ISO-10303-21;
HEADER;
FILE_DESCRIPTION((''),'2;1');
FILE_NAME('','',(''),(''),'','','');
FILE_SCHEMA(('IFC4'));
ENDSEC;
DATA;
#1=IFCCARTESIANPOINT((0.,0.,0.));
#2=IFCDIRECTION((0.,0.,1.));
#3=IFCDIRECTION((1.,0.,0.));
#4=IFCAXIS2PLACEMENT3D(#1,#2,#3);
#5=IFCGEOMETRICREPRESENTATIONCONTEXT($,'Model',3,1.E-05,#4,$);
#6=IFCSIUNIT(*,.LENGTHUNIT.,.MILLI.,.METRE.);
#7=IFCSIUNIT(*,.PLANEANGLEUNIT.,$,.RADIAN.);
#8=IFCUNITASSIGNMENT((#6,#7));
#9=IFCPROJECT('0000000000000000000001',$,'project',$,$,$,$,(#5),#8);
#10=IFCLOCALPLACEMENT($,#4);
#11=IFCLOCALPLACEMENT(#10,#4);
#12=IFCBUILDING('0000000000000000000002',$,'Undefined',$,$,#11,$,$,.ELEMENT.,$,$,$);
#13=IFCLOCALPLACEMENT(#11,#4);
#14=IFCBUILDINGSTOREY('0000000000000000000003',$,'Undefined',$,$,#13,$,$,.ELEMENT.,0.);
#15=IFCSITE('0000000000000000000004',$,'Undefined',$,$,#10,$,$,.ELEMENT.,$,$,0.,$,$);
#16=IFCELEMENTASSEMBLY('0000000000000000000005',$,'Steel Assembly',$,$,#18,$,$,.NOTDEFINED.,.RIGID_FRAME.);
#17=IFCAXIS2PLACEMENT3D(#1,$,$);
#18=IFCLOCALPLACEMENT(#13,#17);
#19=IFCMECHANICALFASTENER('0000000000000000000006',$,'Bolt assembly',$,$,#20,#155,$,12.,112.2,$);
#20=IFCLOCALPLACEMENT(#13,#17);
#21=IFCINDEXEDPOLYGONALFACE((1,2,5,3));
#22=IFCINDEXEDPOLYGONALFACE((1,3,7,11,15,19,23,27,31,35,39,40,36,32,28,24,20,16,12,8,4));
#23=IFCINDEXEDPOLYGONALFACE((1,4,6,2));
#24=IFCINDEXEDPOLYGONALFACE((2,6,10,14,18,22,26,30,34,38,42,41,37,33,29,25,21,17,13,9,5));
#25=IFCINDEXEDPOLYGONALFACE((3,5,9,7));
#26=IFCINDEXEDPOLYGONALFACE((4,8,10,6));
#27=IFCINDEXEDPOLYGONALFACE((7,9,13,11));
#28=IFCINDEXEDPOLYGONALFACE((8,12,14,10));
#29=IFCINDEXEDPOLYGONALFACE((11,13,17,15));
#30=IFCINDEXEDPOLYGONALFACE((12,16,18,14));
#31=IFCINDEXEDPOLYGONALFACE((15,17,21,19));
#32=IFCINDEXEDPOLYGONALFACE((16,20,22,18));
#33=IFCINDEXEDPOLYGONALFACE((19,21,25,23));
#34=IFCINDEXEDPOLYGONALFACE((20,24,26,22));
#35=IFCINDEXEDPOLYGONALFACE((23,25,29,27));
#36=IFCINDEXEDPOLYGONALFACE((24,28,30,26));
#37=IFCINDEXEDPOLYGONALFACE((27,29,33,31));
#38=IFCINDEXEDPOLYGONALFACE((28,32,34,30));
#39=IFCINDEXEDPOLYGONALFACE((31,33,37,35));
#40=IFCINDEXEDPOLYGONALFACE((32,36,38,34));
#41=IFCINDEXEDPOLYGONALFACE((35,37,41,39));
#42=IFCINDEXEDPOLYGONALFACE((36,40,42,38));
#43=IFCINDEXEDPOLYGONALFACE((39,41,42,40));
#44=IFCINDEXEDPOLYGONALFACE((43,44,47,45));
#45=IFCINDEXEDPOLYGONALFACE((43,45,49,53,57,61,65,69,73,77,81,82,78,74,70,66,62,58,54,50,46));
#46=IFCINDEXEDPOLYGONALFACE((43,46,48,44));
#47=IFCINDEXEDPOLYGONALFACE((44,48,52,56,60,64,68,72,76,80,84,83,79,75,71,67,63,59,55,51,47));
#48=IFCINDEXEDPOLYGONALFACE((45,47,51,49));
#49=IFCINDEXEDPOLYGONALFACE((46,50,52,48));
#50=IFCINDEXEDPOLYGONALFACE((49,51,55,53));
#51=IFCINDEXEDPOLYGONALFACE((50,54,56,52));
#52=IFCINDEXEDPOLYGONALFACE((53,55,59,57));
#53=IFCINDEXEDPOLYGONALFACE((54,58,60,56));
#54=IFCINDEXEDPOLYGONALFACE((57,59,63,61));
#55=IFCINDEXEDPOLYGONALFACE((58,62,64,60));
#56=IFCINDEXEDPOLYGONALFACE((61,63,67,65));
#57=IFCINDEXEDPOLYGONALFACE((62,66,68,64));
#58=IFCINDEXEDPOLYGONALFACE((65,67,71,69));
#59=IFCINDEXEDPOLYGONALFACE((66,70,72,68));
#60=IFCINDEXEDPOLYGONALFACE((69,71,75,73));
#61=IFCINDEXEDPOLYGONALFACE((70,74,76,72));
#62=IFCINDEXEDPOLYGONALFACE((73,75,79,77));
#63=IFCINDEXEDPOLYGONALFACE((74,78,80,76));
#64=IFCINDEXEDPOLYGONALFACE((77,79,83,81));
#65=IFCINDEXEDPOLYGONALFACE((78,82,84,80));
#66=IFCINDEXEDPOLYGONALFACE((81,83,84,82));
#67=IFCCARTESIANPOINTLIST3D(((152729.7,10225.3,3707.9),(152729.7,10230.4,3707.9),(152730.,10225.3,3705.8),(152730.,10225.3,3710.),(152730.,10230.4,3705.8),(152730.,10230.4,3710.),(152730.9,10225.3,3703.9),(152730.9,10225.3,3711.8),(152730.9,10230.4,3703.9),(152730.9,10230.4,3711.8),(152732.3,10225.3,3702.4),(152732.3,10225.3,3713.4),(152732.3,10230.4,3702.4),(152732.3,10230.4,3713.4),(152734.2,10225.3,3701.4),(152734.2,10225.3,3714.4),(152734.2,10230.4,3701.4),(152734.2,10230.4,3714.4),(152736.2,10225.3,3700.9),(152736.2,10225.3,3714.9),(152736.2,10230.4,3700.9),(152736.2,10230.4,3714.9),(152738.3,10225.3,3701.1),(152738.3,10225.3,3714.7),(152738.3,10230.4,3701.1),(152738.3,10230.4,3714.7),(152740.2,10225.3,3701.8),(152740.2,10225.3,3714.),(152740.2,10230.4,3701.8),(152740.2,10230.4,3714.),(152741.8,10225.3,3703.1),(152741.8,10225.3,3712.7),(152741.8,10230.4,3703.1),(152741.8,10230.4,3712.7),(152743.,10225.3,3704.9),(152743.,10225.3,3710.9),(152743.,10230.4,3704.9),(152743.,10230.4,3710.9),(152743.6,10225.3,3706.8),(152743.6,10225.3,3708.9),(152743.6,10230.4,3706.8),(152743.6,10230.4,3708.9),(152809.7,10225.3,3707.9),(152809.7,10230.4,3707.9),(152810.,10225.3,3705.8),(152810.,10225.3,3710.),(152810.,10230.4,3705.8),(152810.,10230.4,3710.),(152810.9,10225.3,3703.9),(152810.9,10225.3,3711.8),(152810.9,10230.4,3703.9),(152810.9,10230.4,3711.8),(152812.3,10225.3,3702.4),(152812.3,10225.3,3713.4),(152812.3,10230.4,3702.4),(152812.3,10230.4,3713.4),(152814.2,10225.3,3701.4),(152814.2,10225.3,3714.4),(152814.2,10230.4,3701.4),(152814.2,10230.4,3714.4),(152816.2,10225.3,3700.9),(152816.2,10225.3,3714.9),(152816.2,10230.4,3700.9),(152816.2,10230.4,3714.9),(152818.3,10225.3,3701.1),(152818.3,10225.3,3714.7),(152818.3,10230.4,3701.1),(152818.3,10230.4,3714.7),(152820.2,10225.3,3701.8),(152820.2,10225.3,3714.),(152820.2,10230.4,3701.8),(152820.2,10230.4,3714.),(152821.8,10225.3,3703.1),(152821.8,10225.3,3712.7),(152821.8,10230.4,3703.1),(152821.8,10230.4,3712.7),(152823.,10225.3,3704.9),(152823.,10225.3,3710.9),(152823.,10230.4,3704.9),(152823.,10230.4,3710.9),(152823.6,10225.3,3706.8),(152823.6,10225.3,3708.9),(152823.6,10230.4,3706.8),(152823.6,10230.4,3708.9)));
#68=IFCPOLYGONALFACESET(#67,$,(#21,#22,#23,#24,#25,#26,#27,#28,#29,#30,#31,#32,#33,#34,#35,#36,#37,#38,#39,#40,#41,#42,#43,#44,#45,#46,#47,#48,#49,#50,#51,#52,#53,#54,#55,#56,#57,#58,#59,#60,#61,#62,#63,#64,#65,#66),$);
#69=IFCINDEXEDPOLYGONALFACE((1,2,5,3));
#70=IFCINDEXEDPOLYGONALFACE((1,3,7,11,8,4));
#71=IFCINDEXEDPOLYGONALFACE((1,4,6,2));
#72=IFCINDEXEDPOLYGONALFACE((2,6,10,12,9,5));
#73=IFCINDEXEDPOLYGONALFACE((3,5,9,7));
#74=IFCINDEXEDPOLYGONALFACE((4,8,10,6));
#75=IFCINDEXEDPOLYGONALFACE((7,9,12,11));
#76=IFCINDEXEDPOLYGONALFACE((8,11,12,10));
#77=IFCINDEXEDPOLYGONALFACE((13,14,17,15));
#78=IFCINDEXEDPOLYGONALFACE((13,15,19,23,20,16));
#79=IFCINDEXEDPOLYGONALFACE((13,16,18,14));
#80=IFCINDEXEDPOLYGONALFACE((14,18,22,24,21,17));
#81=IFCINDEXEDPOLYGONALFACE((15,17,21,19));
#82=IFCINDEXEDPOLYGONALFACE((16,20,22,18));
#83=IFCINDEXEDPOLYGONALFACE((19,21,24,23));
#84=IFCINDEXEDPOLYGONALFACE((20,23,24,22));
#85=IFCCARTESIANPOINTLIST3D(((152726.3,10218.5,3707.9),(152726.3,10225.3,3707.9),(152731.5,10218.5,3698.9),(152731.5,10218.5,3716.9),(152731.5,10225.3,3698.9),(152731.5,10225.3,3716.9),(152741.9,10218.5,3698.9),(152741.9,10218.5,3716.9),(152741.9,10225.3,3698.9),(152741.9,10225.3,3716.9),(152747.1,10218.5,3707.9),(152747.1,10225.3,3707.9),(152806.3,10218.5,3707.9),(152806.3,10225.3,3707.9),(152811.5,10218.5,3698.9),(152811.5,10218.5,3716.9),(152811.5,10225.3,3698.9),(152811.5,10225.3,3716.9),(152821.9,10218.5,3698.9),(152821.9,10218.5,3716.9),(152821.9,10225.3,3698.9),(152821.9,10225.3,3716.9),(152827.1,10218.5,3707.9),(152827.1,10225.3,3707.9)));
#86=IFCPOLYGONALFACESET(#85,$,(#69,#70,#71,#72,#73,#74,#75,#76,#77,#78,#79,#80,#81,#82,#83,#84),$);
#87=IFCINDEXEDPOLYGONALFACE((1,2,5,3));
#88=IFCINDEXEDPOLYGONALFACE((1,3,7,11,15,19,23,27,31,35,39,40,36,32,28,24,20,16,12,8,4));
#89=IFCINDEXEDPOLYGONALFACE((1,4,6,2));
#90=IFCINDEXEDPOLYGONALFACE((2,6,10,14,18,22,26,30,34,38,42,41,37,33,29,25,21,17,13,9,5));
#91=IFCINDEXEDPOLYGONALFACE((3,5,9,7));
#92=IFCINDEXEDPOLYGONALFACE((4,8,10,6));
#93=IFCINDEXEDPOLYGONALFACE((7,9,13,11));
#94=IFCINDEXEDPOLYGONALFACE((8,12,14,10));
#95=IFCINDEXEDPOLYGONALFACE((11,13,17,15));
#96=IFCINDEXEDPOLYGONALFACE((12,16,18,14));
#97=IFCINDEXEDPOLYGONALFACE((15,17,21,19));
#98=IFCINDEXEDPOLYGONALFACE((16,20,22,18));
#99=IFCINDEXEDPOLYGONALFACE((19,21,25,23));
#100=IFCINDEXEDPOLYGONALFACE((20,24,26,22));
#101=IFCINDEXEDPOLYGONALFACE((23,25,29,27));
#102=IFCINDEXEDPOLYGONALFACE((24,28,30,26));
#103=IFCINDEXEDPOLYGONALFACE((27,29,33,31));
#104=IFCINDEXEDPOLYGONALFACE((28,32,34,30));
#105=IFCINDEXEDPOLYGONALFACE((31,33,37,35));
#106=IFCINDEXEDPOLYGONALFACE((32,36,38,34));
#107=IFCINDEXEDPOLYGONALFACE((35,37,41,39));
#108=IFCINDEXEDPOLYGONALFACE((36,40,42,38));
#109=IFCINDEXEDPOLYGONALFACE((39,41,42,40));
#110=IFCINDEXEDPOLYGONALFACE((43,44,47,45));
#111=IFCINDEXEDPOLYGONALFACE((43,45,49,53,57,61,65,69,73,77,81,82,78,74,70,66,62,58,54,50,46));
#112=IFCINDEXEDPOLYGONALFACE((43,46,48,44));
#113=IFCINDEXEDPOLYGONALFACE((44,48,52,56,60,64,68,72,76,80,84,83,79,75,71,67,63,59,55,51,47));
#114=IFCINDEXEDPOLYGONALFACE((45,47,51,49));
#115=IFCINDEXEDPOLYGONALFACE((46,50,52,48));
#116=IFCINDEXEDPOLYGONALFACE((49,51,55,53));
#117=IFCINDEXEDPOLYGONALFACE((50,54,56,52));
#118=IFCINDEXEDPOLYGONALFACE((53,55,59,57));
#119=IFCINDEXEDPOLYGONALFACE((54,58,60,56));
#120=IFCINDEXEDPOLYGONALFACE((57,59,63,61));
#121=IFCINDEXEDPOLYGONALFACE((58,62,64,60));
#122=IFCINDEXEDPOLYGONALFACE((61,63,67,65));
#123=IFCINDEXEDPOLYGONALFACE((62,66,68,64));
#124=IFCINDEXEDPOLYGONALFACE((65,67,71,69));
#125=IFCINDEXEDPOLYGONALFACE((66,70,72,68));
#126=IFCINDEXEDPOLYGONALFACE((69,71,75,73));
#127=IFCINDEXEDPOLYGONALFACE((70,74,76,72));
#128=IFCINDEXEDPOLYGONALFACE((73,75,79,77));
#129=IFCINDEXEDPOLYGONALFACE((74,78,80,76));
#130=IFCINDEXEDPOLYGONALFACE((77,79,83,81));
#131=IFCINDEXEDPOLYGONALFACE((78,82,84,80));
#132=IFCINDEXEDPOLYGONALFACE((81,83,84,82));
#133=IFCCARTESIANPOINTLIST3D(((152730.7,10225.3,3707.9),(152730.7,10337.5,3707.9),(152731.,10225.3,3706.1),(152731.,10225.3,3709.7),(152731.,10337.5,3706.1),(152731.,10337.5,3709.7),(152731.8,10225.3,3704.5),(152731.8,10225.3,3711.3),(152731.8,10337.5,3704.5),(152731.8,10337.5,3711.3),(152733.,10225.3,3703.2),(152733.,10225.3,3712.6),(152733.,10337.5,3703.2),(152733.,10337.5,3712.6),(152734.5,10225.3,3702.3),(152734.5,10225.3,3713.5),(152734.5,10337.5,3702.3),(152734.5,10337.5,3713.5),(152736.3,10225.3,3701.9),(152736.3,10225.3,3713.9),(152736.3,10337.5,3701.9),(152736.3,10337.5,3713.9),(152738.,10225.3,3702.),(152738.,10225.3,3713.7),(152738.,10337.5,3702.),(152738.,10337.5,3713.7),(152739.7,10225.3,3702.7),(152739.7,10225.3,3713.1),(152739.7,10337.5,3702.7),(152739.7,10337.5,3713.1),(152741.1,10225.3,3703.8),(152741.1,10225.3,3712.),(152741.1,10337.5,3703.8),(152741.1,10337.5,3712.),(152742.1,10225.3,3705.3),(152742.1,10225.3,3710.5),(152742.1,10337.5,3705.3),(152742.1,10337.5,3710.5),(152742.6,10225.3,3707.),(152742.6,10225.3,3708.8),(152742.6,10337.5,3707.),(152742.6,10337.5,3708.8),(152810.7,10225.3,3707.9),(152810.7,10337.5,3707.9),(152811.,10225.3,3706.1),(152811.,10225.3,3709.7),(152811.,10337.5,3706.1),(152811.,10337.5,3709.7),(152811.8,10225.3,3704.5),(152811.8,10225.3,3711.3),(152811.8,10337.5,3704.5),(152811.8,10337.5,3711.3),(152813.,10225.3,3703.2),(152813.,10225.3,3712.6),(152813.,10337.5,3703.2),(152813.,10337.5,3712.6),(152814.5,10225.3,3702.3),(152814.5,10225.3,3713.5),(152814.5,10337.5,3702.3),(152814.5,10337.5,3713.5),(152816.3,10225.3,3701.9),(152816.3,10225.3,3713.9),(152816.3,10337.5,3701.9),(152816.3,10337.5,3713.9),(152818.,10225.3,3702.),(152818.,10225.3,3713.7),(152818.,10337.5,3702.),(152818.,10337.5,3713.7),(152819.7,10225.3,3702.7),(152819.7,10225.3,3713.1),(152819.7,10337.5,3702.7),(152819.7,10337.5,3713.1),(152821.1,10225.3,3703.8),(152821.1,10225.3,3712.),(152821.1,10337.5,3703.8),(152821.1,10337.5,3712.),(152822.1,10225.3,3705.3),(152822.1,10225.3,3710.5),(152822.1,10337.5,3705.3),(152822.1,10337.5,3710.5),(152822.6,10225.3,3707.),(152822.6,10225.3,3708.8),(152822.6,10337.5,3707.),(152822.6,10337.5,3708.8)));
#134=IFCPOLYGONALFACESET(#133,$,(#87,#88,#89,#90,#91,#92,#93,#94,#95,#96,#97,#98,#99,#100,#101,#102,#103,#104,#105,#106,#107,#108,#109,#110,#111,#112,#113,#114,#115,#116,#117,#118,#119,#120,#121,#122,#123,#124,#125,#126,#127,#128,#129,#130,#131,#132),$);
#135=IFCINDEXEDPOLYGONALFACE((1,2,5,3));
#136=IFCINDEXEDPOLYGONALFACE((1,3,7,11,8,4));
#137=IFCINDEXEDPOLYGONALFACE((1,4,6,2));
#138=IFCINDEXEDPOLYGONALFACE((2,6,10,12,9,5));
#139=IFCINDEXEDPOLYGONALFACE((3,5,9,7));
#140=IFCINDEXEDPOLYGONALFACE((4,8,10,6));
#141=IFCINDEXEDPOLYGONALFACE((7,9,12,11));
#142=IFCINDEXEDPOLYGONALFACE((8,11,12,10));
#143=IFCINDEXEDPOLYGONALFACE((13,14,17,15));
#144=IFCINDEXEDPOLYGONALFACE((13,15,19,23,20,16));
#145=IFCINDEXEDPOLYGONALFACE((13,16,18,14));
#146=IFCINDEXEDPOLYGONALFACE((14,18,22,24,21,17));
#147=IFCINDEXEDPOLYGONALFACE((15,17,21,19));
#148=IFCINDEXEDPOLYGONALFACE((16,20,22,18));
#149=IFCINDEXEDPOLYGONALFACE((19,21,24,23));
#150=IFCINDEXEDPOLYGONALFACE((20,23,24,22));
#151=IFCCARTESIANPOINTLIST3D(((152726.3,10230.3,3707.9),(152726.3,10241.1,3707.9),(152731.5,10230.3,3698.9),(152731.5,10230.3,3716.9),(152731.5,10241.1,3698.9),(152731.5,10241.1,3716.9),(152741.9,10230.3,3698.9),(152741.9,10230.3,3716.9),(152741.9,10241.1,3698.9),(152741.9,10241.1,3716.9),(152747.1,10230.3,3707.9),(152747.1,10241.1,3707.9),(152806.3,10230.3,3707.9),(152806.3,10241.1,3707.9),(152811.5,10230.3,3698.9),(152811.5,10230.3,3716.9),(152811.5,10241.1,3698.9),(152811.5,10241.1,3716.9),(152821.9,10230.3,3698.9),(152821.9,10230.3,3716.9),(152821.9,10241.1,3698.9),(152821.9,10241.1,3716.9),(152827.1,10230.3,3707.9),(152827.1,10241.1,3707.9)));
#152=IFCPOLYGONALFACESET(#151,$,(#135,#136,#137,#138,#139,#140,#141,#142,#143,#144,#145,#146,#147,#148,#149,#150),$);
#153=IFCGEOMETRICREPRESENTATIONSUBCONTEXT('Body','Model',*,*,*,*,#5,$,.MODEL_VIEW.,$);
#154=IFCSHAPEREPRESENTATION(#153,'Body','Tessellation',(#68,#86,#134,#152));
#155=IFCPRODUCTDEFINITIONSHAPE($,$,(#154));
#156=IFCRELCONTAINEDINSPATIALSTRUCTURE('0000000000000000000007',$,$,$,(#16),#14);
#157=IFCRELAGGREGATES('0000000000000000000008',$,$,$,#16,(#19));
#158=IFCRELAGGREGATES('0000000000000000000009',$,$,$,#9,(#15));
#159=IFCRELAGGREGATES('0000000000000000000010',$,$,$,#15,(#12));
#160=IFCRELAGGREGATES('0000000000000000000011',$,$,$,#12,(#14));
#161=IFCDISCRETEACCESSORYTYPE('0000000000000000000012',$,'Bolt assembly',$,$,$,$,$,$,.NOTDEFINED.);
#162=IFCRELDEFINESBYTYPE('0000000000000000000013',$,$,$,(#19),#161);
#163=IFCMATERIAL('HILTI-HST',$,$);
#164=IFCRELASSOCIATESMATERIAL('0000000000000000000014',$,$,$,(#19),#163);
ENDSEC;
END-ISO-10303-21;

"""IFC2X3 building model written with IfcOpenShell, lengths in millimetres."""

from ifc_helpers import new_model, si_unit, frame, origin_with_axes, origin_2d_with_axis, place, context, subcontext, project, spatial, polyline, circle, outline, extrude, source, transform, mapped, material, type_object, element, aggregate, save


model = new_model("IFC2X3")

# Units and contexts
model_context = context("Model", 3, precision=1e-05, world=origin_with_axes())
body_context = subcontext(model_context, "Body", "Model", "MODEL_VIEW")
ifc_project = project(units=[si_unit("LENGTHUNIT", "METRE", prefix="MILLI"), si_unit("PLANEANGLEUNIT", "RADIAN")], contexts=[model_context])

# Site, building, storey
site_placement = place(None, origin_with_axes())
site = spatial("IfcSite", under=ifc_project, at=site_placement, Name="Undefined", CompositionType="ELEMENT", RefElevation=0.0)
building_placement = place(site_placement, origin_with_axes())
building = spatial("IfcBuilding", under=site, at=building_placement, Name="Undefined", CompositionType="ELEMENT")
storey_placement = place(building_placement, origin_with_axes())
storey = spatial("IfcBuildingStorey", under=building, at=storey_placement, Name="Undefined", CompositionType="ELEMENT", Elevation=0.0)

# Element assembly
assembly_1_placement = place(storey_placement, origin_with_axes())
assembly_1 = element("IfcElementAssembly", 1, at=assembly_1_placement, inside=storey, Name="Steel Assembly", AssemblyPlace="NOTDEFINED", PredefinedType="RIGID_FRAME")

# Mechanical fastener
ifc_material_1 = material(Name="HILTI-HST")
discrete_accessory_type_1 = type_object("IfcDiscreteAccessoryType", Name="Bolt assembly")
shared_shape_1 = source(origin_with_axes(), body_context, "Body", "SweptSolid", [
    extrude(circle(Radius=7.0, at=origin_2d_with_axis()), frame((0.0, 0.0, 0.0), z_axis=(0.0, 1.0, 0.0), x_axis=(1.0, 0.0, 0.0)), (0.0, 0.0, 1.0), 5.1),
    extrude(outline(polyline([(10.4, 0.0), (5.2, 9.0), (-5.2, 9.0), (-10.4, 0.0), (-5.2, -9.0), (5.2, -9.0), (10.4, 0.0)])), frame((0.0, -6.8, 0.0), z_axis=(0.0, 1.0, 0.0), x_axis=(1.0, 0.0, 0.0)), (0.0, 0.0, 1.0), 6.8),
    extrude(circle(Radius=6.0, at=origin_2d_with_axis()), frame((0.0, 0.0, 0.0), z_axis=(0.0, 1.0, 0.0), x_axis=(1.0, 0.0, 0.0)), (0.0, 0.0, 1.0), 112.2),
    extrude(outline(polyline([(10.4, 0.0), (5.2, 9.0), (-5.2, 9.0), (-10.4, 0.0), (-5.2, -9.0), (5.2, -9.0), (10.4, 0.0)])), frame((0.0, 5.0, 0.0), z_axis=(0.0, 1.0, 0.0), x_axis=(1.0, 0.0, 0.0)), (0.0, 0.0, 1.0), 10.8),
])
mechanical_fastener_1_placement = place(assembly_1_placement, frame((152816.7, 10225.3, 3707.9), z_axis=(0.0, 0.0, -1.0), x_axis=(-1.0, 0.0, 0.0)))
mechanical_fastener_1 = element("IfcMechanicalFastener", 2, at=mechanical_fastener_1_placement, type_object=discrete_accessory_type_1, material=ifc_material_1, Name="Bolt assembly", NominalDiameter=12.0, NominalLength=112.2, context=body_context, shape_type="MappedRepresentation", body=[
    mapped(shared_shape_1, transform((0.0, 0.0, 0.0))),
    mapped(shared_shape_1, transform((80.0, 0.0, 0.0))),
])
aggregate(assembly_1, [mechanical_fastener_1])

save(model, "model.ifc")
